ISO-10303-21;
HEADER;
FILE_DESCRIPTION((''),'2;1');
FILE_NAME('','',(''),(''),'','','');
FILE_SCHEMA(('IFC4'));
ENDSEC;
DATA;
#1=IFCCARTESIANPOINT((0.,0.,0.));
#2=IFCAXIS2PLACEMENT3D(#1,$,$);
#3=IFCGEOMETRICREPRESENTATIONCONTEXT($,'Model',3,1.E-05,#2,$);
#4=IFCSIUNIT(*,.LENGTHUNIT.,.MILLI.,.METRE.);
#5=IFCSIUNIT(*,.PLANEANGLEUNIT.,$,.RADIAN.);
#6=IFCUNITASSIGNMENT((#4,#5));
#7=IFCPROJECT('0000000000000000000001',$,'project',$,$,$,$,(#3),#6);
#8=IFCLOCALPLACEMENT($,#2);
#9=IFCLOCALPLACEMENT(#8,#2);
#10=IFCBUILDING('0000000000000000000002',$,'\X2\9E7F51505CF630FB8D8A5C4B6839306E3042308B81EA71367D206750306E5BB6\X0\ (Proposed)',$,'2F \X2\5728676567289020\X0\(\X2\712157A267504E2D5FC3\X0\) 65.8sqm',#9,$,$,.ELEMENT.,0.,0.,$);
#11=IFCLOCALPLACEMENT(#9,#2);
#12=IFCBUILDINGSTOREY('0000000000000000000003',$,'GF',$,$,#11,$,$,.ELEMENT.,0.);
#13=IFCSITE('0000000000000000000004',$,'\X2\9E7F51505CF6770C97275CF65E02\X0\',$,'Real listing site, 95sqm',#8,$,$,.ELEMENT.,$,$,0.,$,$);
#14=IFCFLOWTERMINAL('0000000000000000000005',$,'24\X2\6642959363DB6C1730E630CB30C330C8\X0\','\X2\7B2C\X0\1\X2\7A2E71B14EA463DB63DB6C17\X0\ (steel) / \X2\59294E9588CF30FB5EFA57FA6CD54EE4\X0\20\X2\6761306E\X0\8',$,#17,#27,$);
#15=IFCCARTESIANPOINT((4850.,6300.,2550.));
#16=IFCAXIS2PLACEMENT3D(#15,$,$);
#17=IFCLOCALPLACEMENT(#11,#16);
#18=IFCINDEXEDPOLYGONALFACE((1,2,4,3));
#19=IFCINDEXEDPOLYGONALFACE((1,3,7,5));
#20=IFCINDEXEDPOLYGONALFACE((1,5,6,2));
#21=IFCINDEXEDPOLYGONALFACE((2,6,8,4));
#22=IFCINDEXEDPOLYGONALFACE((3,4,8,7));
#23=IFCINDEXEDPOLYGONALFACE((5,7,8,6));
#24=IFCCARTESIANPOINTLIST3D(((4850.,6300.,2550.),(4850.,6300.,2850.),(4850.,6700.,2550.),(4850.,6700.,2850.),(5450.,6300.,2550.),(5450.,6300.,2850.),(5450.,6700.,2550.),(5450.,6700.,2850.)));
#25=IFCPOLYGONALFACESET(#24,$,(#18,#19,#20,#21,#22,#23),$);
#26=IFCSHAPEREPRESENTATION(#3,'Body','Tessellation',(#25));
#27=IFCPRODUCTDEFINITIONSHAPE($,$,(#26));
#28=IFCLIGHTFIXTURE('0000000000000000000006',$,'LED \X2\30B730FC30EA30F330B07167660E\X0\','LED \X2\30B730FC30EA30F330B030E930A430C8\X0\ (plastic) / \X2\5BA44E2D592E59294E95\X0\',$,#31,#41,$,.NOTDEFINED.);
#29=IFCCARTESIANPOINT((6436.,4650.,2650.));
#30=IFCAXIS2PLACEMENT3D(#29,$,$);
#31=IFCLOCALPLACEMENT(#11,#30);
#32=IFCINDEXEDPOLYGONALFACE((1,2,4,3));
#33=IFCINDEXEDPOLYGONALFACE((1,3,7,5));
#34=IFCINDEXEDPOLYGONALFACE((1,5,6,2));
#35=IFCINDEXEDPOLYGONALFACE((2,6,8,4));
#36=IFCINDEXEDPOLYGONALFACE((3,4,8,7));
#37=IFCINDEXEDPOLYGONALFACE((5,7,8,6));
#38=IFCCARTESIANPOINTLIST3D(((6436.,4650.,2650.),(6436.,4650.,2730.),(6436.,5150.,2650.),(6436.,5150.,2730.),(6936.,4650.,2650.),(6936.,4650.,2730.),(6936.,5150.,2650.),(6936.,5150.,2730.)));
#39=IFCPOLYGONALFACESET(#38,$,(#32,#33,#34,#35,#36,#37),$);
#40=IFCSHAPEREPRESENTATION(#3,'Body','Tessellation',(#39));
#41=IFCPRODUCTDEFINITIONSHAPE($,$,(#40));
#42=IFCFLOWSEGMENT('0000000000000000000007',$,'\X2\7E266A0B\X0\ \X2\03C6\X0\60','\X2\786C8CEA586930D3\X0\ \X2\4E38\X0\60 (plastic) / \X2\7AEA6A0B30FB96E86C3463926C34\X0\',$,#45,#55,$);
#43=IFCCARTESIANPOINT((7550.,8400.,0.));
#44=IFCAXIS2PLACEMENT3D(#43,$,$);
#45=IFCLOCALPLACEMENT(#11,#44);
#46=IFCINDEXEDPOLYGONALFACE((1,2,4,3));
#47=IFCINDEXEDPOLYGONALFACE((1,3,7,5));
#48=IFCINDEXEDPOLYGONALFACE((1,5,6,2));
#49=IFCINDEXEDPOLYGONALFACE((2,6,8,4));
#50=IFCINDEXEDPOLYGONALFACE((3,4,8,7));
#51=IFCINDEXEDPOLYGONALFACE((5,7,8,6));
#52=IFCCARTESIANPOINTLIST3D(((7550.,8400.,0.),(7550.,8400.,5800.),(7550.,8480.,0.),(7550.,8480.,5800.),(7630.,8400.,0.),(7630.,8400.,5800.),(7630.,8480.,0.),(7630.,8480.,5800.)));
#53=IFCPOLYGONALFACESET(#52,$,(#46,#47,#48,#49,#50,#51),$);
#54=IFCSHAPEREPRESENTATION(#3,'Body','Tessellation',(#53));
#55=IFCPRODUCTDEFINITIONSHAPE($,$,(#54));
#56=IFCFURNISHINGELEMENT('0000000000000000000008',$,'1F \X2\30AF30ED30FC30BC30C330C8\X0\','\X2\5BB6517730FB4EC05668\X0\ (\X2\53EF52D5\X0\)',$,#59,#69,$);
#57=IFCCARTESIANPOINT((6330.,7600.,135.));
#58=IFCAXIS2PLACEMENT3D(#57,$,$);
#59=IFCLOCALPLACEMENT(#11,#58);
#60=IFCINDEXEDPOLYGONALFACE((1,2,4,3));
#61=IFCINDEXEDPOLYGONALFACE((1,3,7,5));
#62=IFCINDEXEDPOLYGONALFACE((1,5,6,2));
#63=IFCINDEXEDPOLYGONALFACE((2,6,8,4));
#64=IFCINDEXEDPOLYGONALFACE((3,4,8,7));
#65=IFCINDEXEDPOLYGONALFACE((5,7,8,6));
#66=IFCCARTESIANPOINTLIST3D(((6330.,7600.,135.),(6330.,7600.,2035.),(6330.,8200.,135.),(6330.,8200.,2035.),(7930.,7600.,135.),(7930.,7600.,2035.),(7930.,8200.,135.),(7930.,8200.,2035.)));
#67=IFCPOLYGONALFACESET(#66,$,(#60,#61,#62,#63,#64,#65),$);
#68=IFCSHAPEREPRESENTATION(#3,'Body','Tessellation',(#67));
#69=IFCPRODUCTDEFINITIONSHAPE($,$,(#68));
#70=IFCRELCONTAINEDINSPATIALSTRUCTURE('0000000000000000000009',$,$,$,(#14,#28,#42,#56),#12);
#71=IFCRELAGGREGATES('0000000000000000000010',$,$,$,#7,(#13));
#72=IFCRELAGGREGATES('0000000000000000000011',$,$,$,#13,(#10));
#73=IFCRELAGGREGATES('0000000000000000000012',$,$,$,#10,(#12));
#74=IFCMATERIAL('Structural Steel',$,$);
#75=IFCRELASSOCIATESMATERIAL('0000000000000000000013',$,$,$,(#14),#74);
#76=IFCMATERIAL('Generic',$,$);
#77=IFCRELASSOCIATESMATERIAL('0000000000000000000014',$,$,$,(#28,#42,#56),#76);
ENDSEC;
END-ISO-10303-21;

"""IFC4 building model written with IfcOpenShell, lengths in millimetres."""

from ifc_helpers import new_model, si_unit, frame, frame_2d, origin, place, context, project, spatial, rectangle, extrude, material, element, save


model = new_model("IFC4")

# Units and contexts
model_context = context("Model", 3, precision=1e-05, world=origin())
ifc_project = project(units=[si_unit("LENGTHUNIT", "METRE", prefix="MILLI"), si_unit("PLANEANGLEUNIT", "RADIAN")], contexts=[model_context])

# Site, building, storey
site_placement = place(None, origin())
site = spatial("IfcSite", under=ifc_project, at=site_placement, Name="鹿児島県霧島市", ObjectType="Real listing site, 95sqm", CompositionType="ELEMENT", RefElevation=0.0)
building_placement = place(site_placement, origin())
building = spatial("IfcBuilding", under=site, at=building_placement, Name="鹿児島・越屋根のある自然素材の家 (Proposed)", ObjectType="2F 在来木造(無垢材中心) 65.8sqm", CompositionType="ELEMENT", ElevationOfRefHeight=0.0, ElevationOfTerrain=0.0)
storey_placement = place(building_placement, origin())
storey = spatial("IfcBuildingStorey", under=building, at=storey_placement, Name="GF", CompositionType="ELEMENT", Elevation=0.0)

# Shared definitions
ifc_material_1 = material(Name="Generic")

# Flow terminal
ifc_material_2 = material(Name="Structural Steel")
flow_terminal_placement = place(storey_placement, frame((4850.0, 6300.0, 2550.0)))
element("IfcFlowTerminal", 1, at=flow_terminal_placement, inside=storey, material=ifc_material_2, Name="24時間換気ユニット", Description="第1種熱交換換気 (steel) / 天井裏・建基法令20条の8", context=model_context, shape_type="SweptSolid", body=[
    extrude(rectangle(XDim=600.0, YDim=400.0, at=frame_2d((300.0, 200.0))), frame((4850.0, 6300.0, 2550.0)), (0.0, 0.0, 1.0), 300.0),
])

# Light fixture
light_fixture_placement = place(storey_placement, frame((6436.0, 4650.0, 2650.0)))
element("IfcLightFixture", 2, at=light_fixture_placement, inside=storey, material=ifc_material_1, Name="LED シーリング照明", Description="LED シーリングライト (plastic) / 室中央天井", PredefinedType="NOTDEFINED", context=model_context, shape_type="SweptSolid", body=[
    extrude(rectangle(XDim=500.0, YDim=500.0, at=frame_2d((250.0, 250.0))), frame((6436.0, 4650.0, 2650.0)), (0.0, 0.0, 1.0), 80.0),
])

# Flow segment
flow_segment_placement = place(storey_placement, frame((7550.0, 8400.0, 0.0)))
element("IfcFlowSegment", 3, at=flow_segment_placement, inside=storey, material=ifc_material_1, Name="縦樋 φ60", Description="硬質塩ビ 丸60 (plastic) / 竪樋・雨水排水", context=model_context, shape_type="SweptSolid", body=[
    extrude(rectangle(XDim=80.0, YDim=80.0, at=frame_2d((40.0, 40.0))), frame((7550.0, 8400.0, 0.0)), (0.0, 0.0, 1.0), 5800.0),
])

# Furnishing element
furnishing_placement = place(storey_placement, frame((6330.0, 7600.0, 135.0)))
element("IfcFurnishingElement", 4, at=furnishing_placement, inside=storey, material=ifc_material_1, Name="1F クローゼット", Description="家具・什器 (可動)", context=model_context, shape_type="SweptSolid", body=[
    extrude(rectangle(XDim=1600.0, YDim=600.0, at=frame_2d((800.0, 300.0))), frame((6330.0, 7600.0, 135.0)), (0.0, 0.0, 1.0), 1900.0),
])

save(model, "model.ifc")
